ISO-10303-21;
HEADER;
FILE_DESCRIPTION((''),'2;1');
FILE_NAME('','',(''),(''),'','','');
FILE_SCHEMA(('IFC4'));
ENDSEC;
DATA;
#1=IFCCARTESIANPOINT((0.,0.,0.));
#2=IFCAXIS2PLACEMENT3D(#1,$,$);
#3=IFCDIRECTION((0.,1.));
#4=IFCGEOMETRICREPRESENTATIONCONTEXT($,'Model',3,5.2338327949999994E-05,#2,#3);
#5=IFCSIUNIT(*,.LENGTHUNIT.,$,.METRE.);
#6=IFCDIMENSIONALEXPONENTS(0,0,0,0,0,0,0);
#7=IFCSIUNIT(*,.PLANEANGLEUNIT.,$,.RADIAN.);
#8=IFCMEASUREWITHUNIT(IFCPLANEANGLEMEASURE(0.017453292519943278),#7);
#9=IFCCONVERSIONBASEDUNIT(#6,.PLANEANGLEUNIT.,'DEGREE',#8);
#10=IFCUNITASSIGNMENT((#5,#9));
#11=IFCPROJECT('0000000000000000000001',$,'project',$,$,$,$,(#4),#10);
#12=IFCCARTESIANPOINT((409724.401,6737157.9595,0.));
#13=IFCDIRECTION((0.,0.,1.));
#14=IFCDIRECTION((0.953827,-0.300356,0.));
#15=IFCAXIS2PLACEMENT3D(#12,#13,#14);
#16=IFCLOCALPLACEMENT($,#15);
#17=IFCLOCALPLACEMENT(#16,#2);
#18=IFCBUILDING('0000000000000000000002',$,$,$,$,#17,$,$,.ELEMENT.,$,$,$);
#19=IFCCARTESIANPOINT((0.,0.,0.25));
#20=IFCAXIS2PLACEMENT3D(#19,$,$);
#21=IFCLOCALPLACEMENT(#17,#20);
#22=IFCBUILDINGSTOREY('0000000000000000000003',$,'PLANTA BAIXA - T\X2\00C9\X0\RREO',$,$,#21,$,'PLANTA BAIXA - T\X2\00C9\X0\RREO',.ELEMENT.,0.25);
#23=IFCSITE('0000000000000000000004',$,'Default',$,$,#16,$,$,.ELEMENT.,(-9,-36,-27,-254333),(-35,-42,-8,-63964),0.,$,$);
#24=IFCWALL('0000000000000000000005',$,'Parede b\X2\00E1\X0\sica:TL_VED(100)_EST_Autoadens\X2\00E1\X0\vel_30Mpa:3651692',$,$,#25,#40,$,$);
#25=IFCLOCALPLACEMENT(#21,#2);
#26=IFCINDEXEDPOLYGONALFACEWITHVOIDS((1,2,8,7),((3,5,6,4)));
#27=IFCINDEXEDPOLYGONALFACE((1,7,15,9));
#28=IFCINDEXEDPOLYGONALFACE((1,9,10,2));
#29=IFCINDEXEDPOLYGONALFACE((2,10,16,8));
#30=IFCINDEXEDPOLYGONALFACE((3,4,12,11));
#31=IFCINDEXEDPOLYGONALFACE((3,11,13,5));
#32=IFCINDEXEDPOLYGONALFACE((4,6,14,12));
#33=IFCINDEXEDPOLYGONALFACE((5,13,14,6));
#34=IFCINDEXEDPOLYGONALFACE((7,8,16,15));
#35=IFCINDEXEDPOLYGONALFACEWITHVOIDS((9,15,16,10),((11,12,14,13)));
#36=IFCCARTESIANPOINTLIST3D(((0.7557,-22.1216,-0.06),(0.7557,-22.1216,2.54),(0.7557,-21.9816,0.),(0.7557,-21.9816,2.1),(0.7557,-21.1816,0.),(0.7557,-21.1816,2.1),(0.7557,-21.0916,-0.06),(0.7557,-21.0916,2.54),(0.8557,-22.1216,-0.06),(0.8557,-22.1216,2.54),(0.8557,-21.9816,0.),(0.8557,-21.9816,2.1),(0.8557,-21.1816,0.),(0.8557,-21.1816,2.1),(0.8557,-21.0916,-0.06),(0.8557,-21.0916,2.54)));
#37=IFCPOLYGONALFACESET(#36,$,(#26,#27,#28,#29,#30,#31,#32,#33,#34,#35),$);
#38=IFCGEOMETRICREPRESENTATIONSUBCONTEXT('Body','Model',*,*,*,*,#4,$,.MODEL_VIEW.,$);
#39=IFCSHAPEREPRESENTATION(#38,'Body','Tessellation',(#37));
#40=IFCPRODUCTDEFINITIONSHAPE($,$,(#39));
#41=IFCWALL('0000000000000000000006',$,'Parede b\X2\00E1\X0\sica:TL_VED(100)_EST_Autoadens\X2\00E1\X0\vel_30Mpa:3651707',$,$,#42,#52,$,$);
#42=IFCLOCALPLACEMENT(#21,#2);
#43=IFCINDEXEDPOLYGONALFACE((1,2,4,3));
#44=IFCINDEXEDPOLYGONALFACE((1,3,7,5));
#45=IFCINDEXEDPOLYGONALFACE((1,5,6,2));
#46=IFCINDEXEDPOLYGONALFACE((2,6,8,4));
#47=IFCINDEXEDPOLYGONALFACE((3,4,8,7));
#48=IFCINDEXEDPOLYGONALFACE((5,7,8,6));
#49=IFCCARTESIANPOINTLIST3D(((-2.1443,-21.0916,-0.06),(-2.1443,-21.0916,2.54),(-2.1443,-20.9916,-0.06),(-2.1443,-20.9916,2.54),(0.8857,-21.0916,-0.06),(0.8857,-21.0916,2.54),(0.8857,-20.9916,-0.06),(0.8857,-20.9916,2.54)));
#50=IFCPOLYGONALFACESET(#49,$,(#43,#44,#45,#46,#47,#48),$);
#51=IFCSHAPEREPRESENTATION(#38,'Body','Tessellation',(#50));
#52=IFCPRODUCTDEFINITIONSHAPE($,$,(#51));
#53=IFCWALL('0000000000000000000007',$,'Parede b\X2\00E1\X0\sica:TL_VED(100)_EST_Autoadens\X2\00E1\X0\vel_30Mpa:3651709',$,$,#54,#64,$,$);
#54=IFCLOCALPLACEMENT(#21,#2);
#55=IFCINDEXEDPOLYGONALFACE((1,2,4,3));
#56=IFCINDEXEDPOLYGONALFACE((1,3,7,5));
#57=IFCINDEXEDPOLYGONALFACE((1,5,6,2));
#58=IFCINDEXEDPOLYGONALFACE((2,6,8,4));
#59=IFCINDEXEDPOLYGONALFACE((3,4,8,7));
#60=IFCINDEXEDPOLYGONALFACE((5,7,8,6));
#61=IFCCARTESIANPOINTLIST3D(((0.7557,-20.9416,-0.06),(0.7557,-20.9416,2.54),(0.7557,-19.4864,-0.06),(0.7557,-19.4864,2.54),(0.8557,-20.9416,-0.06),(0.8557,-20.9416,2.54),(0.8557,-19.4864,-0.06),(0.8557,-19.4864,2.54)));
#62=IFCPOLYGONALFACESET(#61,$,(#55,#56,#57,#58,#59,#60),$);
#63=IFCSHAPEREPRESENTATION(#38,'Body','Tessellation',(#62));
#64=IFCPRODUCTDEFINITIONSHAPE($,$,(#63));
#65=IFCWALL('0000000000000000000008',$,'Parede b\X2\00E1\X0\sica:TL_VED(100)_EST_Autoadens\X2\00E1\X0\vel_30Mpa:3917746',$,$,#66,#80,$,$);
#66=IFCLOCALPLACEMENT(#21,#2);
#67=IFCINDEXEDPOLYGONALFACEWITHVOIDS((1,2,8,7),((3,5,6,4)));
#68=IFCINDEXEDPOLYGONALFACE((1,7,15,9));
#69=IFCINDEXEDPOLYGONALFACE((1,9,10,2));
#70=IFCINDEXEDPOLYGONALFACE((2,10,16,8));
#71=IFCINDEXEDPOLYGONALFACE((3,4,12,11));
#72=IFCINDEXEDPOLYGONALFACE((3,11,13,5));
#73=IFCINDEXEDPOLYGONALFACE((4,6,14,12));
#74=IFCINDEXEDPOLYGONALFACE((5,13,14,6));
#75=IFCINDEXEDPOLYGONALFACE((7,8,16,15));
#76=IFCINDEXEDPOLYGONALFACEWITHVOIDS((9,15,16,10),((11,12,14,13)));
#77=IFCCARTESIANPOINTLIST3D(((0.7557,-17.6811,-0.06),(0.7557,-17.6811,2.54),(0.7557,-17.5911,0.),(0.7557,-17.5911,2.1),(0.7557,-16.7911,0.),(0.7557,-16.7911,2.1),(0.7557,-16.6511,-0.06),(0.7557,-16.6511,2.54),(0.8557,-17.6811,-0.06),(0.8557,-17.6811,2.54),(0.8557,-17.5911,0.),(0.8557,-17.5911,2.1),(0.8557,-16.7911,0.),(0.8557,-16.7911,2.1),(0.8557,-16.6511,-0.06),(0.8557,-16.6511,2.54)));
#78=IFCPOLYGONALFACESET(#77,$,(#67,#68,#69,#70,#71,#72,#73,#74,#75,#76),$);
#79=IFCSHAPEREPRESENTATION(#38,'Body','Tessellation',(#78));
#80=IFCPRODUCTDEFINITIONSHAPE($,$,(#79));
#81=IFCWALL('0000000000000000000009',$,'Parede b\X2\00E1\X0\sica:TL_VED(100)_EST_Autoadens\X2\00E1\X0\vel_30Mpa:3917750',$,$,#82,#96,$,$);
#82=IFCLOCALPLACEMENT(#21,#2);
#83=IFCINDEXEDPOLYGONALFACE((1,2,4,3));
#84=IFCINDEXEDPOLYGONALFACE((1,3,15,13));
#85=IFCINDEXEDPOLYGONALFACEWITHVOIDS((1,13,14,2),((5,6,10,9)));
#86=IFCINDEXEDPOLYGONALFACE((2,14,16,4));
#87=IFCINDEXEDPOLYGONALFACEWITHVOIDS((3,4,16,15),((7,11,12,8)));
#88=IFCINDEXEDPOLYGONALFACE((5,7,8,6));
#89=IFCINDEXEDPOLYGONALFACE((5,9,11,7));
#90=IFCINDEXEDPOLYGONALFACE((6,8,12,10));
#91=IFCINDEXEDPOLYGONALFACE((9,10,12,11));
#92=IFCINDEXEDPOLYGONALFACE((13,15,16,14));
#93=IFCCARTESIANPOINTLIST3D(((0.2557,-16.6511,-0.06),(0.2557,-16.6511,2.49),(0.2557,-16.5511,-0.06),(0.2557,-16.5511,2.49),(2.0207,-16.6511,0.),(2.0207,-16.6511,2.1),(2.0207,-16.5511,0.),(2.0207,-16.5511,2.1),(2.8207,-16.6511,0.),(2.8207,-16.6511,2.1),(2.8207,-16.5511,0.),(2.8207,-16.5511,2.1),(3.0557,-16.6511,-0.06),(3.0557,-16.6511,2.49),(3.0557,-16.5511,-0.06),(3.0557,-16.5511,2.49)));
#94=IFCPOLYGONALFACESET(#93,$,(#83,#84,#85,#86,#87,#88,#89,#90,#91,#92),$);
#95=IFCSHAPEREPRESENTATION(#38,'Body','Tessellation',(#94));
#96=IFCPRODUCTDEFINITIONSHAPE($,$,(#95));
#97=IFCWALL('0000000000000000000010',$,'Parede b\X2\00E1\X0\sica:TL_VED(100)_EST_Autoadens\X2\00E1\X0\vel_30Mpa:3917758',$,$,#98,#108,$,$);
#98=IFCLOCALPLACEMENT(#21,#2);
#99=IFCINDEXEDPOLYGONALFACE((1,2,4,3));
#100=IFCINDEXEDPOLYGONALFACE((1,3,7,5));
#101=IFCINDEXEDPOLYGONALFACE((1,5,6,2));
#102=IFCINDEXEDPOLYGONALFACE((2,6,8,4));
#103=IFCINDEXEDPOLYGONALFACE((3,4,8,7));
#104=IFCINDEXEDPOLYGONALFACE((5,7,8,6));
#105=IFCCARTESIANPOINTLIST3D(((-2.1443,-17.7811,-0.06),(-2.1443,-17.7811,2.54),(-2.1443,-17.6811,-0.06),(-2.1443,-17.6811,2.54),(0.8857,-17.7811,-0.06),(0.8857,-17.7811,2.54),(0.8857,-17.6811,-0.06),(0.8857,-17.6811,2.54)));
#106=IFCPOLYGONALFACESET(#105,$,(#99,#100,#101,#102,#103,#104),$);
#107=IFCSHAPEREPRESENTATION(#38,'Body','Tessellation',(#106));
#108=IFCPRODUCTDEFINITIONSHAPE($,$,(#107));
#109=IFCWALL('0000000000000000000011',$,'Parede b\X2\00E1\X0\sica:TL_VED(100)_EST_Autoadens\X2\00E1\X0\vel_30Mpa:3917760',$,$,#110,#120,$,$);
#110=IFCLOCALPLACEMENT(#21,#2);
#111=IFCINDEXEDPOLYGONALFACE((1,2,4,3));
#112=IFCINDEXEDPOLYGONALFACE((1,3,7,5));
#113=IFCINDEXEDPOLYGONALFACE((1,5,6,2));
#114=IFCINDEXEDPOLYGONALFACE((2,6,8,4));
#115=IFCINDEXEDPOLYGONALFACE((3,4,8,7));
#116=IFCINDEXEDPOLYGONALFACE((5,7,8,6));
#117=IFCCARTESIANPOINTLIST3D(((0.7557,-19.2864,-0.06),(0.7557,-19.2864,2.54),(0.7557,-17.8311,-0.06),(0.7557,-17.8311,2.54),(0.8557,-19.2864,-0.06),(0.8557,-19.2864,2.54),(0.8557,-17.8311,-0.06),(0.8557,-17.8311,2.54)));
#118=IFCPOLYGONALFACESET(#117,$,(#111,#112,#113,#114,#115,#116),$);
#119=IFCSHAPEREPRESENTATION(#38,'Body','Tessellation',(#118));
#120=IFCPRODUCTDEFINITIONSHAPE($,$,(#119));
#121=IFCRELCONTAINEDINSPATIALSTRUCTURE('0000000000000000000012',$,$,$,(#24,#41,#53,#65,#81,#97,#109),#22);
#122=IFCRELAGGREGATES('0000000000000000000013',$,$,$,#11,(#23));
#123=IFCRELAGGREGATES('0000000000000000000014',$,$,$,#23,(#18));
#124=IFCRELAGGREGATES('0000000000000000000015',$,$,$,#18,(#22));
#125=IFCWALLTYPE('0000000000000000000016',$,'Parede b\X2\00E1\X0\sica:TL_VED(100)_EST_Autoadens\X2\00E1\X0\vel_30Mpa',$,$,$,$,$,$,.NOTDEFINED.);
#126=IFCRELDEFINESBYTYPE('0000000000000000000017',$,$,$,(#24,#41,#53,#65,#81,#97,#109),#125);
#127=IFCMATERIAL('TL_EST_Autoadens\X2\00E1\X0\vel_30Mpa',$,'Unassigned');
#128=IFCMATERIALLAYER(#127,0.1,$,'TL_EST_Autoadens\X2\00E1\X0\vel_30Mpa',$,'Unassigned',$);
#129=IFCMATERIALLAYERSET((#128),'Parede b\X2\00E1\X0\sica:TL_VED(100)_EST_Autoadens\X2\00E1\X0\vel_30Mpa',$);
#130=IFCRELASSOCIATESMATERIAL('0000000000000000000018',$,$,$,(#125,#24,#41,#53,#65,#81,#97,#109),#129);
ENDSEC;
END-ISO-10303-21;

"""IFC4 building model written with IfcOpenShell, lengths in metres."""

from ifc_helpers import new_model, entity, si_unit, converted_unit, direction, frame, frame_2d, origin, place, context, subcontext, project, spatial, rectangle, extrude, material, layer, layer_set, layer_usage, type_object, element, save


model = new_model("IFC4")

# Units and contexts
model_context = context("Model", 3, precision=5.2338327949999994e-05, world=origin(), true_north=direction((0.0, 1.0)))
body_context = subcontext(model_context, "Body", "Model", "MODEL_VIEW")
ifc_project = project(units=[si_unit("LENGTHUNIT", "METRE"), converted_unit("PLANEANGLEUNIT", "DEGREE", entity("IfcPlaneAngleMeasure", 0.017453292519943278), si_unit("PLANEANGLEUNIT", "RADIAN"), dimensions=[0, 0, 0, 0, 0, 0, 0])], contexts=[model_context])

# Site, building, storey
site_placement = place(None, frame((409724.401, 6737157.9595, 0.0), z_axis=(0.0, 0.0, 1.0), x_axis=(0.953827, -0.300356, 0.0)))
site = spatial("IfcSite", under=ifc_project, at=site_placement, Name="Default", CompositionType="ELEMENT", RefLatitude=(-9, -36, -27, -254333), RefLongitude=(-35, -42, -8, -63964), RefElevation=0.0)
building_placement = place(site_placement, origin())
building = spatial("IfcBuilding", under=site, at=building_placement, CompositionType="ELEMENT")
storey_placement = place(building_placement, frame((0.0, 0.0, 0.25)))
storey = spatial("IfcBuildingStorey", under=building, at=storey_placement, Name="PLANTA BAIXA - TÉRREO", LongName="PLANTA BAIXA - TÉRREO", CompositionType="ELEMENT", Elevation=0.25)

# Wall, opening
ifc_material_1 = material(Name="TL_EST_Autoadensável_30Mpa", Category="Unassigned")
ifc_layer_1 = layer(ifc_material_1, 0.1, Name="TL_EST_Autoadensável_30Mpa", Category="Unassigned")
ifc_layer_set_1 = layer_set([ifc_layer_1], Name="Parede básica:TL_VED(100)_EST_Autoadensável_30Mpa")
ifc_layer_usage_1 = layer_usage(ifc_layer_set_1, "AXIS2", "NEGATIVE", 0.05)
wall_type_1 = type_object("IfcWallType", Name="Parede básica:TL_VED(100)_EST_Autoadensável_30Mpa", PredefinedType="NOTDEFINED", material=ifc_layer_set_1)
wall_1_placement = place(storey_placement, frame((0.8057, -22.1216, -0.06), z_axis=(0.0, 0.0, 1.0), x_axis=(0.0, 1.0, 0.0)))
wall_1 = element("IfcWall", 1, at=wall_1_placement, inside=storey, type_object=wall_type_1, material=ifc_layer_usage_1, Name="Parede básica:TL_VED(100)_EST_Autoadensável_30Mpa:3651692", context=body_context, shape_type="SweptSolid", body=[
    extrude(rectangle(XDim=1.03, YDim=0.1, at=frame_2d((0.515, 0.0), x_axis=(-1.0, 0.0))), origin(), (0.0, 0.0, 1.0), 2.6),
])
opening_1_placement = place(wall_1_placement, frame((0.14, -0.05, 0.06)))
element("IfcOpeningElement", 2, at=opening_1_placement, cuts=wall_1, PredefinedType="OPENING", context=body_context, shape_type="SweptSolid", body=[
    extrude(rectangle(XDim=2.1, YDim=0.8, at=frame_2d((1.05, 0.4), x_axis=(1.0, 0.0))), frame((0.0, 0.0, 0.0), z_axis=(0.0, 1.0, 0.0), x_axis=(0.0, 0.0, 1.0)), (0.0, 0.0, 1.0), 0.1),
])

# Walls
ifc_layer_usage_2 = layer_usage(ifc_layer_set_1, "AXIS2", "POSITIVE", -0.05)
wall_2_placement = place(storey_placement, frame((0.8857, -21.0416, -0.06), z_axis=(0.0, 0.0, 1.0), x_axis=(-1.0, 0.0, 0.0)))
element("IfcWall", 3, at=wall_2_placement, inside=storey, type_object=wall_type_1, material=ifc_layer_usage_2, Name="Parede básica:TL_VED(100)_EST_Autoadensável_30Mpa:3651707", context=body_context, shape_type="SweptSolid", body=[
    extrude(rectangle(XDim=3.03, YDim=0.1, at=frame_2d((1.515, 0.0), x_axis=(-1.0, 0.0))), origin(), (0.0, 0.0, 1.0), 2.6),
])
ifc_layer_usage_3 = layer_usage(ifc_layer_set_1, "AXIS2", "NEGATIVE", 0.05)
wall_3_placement = place(storey_placement, frame((0.8057, -19.4864, -0.06), z_axis=(0.0, 0.0, 1.0), x_axis=(0.0, -1.0, 0.0)))
element("IfcWall", 4, at=wall_3_placement, inside=storey, type_object=wall_type_1, material=ifc_layer_usage_3, Name="Parede básica:TL_VED(100)_EST_Autoadensável_30Mpa:3651709", context=body_context, shape_type="SweptSolid", body=[
    extrude(rectangle(XDim=1.4552, YDim=0.1, at=frame_2d((0.7276, 0.0), x_axis=(-1.0, 0.0))), origin(), (0.0, 0.0, 1.0), 2.6),
])

# Walls, openings
ifc_layer_usage_4 = layer_usage(ifc_layer_set_1, "AXIS2", "POSITIVE", -0.05)
wall_4_placement = place(storey_placement, frame((0.8057, -16.6511, -0.06), z_axis=(0.0, 0.0, 1.0), x_axis=(0.0, -1.0, 0.0)))
wall_4 = element("IfcWall", 5, at=wall_4_placement, inside=storey, type_object=wall_type_1, material=ifc_layer_usage_4, Name="Parede básica:TL_VED(100)_EST_Autoadensável_30Mpa:3917746", context=body_context, shape_type="SweptSolid", body=[
    extrude(rectangle(XDim=1.03, YDim=0.1, at=frame_2d((0.515, 0.0), x_axis=(-1.0, 0.0))), origin(), (0.0, 0.0, 1.0), 2.6),
])
opening_2_placement = place(wall_4_placement, frame((0.94, 0.05, 0.06)))
element("IfcOpeningElement", 6, at=opening_2_placement, cuts=wall_4, PredefinedType="OPENING", context=body_context, shape_type="SweptSolid", body=[
    extrude(rectangle(XDim=2.1, YDim=0.8, at=frame_2d((1.05, 0.4), x_axis=(1.0, 0.0))), frame((0.0, 0.0, 0.0), z_axis=(0.0, -1.0, 0.0), x_axis=(0.0, 0.0, 1.0)), (0.0, 0.0, 1.0), 0.1),
])
ifc_layer_usage_5 = layer_usage(ifc_layer_set_1, "AXIS2", "POSITIVE", -0.05)
wall_5_placement = place(storey_placement, frame((3.0557, -16.6011, -0.06), z_axis=(0.0, 0.0, 1.0), x_axis=(-1.0, 0.0, 0.0)))
wall_5 = element("IfcWall", 7, at=wall_5_placement, inside=storey, type_object=wall_type_1, material=ifc_layer_usage_5, Name="Parede básica:TL_VED(100)_EST_Autoadensável_30Mpa:3917750", context=body_context, shape_type="SweptSolid", body=[
    extrude(rectangle(XDim=2.8, YDim=0.1, at=frame_2d((1.4, 0.0), x_axis=(-1.0, 0.0))), origin(), (0.0, 0.0, 1.0), 2.55),
])
opening_3_placement = place(wall_5_placement, frame((1.035, 0.05, 0.06)))
element("IfcOpeningElement", 8, at=opening_3_placement, cuts=wall_5, PredefinedType="OPENING", context=body_context, shape_type="SweptSolid", body=[
    extrude(rectangle(XDim=2.1, YDim=0.8, at=frame_2d((1.05, 0.4), x_axis=(1.0, 0.0))), frame((0.0, 0.0, 0.0), z_axis=(0.0, -1.0, 0.0), x_axis=(0.0, 0.0, 1.0)), (0.0, 0.0, 1.0), 0.1),
])

# Walls
ifc_layer_usage_6 = layer_usage(ifc_layer_set_1, "AXIS2", "NEGATIVE", 0.05)
wall_6_placement = place(storey_placement, frame((0.8857, -17.7311, -0.06), z_axis=(0.0, 0.0, 1.0), x_axis=(-1.0, 0.0, 0.0)))
element("IfcWall", 9, at=wall_6_placement, inside=storey, type_object=wall_type_1, material=ifc_layer_usage_6, Name="Parede básica:TL_VED(100)_EST_Autoadensável_30Mpa:3917758", context=body_context, shape_type="SweptSolid", body=[
    extrude(rectangle(XDim=3.03, YDim=0.1, at=frame_2d((1.515, 0.0), x_axis=(-1.0, 0.0))), origin(), (0.0, 0.0, 1.0), 2.6),
])
ifc_layer_usage_7 = layer_usage(ifc_layer_set_1, "AXIS2", "POSITIVE", -0.05)
wall_7_placement = place(storey_placement, frame((0.8057, -19.2864, -0.06), z_axis=(0.0, 0.0, 1.0), x_axis=(0.0, 1.0, 0.0)))
element("IfcWall", 10, at=wall_7_placement, inside=storey, type_object=wall_type_1, material=ifc_layer_usage_7, Name="Parede básica:TL_VED(100)_EST_Autoadensável_30Mpa:3917760", context=body_context, shape_type="SweptSolid", body=[
    extrude(rectangle(XDim=1.4552, YDim=0.1, at=frame_2d((0.7276, 0.0), x_axis=(-1.0, 0.0))), origin(), (0.0, 0.0, 1.0), 2.6),
])

save(model, "model.ifc")
